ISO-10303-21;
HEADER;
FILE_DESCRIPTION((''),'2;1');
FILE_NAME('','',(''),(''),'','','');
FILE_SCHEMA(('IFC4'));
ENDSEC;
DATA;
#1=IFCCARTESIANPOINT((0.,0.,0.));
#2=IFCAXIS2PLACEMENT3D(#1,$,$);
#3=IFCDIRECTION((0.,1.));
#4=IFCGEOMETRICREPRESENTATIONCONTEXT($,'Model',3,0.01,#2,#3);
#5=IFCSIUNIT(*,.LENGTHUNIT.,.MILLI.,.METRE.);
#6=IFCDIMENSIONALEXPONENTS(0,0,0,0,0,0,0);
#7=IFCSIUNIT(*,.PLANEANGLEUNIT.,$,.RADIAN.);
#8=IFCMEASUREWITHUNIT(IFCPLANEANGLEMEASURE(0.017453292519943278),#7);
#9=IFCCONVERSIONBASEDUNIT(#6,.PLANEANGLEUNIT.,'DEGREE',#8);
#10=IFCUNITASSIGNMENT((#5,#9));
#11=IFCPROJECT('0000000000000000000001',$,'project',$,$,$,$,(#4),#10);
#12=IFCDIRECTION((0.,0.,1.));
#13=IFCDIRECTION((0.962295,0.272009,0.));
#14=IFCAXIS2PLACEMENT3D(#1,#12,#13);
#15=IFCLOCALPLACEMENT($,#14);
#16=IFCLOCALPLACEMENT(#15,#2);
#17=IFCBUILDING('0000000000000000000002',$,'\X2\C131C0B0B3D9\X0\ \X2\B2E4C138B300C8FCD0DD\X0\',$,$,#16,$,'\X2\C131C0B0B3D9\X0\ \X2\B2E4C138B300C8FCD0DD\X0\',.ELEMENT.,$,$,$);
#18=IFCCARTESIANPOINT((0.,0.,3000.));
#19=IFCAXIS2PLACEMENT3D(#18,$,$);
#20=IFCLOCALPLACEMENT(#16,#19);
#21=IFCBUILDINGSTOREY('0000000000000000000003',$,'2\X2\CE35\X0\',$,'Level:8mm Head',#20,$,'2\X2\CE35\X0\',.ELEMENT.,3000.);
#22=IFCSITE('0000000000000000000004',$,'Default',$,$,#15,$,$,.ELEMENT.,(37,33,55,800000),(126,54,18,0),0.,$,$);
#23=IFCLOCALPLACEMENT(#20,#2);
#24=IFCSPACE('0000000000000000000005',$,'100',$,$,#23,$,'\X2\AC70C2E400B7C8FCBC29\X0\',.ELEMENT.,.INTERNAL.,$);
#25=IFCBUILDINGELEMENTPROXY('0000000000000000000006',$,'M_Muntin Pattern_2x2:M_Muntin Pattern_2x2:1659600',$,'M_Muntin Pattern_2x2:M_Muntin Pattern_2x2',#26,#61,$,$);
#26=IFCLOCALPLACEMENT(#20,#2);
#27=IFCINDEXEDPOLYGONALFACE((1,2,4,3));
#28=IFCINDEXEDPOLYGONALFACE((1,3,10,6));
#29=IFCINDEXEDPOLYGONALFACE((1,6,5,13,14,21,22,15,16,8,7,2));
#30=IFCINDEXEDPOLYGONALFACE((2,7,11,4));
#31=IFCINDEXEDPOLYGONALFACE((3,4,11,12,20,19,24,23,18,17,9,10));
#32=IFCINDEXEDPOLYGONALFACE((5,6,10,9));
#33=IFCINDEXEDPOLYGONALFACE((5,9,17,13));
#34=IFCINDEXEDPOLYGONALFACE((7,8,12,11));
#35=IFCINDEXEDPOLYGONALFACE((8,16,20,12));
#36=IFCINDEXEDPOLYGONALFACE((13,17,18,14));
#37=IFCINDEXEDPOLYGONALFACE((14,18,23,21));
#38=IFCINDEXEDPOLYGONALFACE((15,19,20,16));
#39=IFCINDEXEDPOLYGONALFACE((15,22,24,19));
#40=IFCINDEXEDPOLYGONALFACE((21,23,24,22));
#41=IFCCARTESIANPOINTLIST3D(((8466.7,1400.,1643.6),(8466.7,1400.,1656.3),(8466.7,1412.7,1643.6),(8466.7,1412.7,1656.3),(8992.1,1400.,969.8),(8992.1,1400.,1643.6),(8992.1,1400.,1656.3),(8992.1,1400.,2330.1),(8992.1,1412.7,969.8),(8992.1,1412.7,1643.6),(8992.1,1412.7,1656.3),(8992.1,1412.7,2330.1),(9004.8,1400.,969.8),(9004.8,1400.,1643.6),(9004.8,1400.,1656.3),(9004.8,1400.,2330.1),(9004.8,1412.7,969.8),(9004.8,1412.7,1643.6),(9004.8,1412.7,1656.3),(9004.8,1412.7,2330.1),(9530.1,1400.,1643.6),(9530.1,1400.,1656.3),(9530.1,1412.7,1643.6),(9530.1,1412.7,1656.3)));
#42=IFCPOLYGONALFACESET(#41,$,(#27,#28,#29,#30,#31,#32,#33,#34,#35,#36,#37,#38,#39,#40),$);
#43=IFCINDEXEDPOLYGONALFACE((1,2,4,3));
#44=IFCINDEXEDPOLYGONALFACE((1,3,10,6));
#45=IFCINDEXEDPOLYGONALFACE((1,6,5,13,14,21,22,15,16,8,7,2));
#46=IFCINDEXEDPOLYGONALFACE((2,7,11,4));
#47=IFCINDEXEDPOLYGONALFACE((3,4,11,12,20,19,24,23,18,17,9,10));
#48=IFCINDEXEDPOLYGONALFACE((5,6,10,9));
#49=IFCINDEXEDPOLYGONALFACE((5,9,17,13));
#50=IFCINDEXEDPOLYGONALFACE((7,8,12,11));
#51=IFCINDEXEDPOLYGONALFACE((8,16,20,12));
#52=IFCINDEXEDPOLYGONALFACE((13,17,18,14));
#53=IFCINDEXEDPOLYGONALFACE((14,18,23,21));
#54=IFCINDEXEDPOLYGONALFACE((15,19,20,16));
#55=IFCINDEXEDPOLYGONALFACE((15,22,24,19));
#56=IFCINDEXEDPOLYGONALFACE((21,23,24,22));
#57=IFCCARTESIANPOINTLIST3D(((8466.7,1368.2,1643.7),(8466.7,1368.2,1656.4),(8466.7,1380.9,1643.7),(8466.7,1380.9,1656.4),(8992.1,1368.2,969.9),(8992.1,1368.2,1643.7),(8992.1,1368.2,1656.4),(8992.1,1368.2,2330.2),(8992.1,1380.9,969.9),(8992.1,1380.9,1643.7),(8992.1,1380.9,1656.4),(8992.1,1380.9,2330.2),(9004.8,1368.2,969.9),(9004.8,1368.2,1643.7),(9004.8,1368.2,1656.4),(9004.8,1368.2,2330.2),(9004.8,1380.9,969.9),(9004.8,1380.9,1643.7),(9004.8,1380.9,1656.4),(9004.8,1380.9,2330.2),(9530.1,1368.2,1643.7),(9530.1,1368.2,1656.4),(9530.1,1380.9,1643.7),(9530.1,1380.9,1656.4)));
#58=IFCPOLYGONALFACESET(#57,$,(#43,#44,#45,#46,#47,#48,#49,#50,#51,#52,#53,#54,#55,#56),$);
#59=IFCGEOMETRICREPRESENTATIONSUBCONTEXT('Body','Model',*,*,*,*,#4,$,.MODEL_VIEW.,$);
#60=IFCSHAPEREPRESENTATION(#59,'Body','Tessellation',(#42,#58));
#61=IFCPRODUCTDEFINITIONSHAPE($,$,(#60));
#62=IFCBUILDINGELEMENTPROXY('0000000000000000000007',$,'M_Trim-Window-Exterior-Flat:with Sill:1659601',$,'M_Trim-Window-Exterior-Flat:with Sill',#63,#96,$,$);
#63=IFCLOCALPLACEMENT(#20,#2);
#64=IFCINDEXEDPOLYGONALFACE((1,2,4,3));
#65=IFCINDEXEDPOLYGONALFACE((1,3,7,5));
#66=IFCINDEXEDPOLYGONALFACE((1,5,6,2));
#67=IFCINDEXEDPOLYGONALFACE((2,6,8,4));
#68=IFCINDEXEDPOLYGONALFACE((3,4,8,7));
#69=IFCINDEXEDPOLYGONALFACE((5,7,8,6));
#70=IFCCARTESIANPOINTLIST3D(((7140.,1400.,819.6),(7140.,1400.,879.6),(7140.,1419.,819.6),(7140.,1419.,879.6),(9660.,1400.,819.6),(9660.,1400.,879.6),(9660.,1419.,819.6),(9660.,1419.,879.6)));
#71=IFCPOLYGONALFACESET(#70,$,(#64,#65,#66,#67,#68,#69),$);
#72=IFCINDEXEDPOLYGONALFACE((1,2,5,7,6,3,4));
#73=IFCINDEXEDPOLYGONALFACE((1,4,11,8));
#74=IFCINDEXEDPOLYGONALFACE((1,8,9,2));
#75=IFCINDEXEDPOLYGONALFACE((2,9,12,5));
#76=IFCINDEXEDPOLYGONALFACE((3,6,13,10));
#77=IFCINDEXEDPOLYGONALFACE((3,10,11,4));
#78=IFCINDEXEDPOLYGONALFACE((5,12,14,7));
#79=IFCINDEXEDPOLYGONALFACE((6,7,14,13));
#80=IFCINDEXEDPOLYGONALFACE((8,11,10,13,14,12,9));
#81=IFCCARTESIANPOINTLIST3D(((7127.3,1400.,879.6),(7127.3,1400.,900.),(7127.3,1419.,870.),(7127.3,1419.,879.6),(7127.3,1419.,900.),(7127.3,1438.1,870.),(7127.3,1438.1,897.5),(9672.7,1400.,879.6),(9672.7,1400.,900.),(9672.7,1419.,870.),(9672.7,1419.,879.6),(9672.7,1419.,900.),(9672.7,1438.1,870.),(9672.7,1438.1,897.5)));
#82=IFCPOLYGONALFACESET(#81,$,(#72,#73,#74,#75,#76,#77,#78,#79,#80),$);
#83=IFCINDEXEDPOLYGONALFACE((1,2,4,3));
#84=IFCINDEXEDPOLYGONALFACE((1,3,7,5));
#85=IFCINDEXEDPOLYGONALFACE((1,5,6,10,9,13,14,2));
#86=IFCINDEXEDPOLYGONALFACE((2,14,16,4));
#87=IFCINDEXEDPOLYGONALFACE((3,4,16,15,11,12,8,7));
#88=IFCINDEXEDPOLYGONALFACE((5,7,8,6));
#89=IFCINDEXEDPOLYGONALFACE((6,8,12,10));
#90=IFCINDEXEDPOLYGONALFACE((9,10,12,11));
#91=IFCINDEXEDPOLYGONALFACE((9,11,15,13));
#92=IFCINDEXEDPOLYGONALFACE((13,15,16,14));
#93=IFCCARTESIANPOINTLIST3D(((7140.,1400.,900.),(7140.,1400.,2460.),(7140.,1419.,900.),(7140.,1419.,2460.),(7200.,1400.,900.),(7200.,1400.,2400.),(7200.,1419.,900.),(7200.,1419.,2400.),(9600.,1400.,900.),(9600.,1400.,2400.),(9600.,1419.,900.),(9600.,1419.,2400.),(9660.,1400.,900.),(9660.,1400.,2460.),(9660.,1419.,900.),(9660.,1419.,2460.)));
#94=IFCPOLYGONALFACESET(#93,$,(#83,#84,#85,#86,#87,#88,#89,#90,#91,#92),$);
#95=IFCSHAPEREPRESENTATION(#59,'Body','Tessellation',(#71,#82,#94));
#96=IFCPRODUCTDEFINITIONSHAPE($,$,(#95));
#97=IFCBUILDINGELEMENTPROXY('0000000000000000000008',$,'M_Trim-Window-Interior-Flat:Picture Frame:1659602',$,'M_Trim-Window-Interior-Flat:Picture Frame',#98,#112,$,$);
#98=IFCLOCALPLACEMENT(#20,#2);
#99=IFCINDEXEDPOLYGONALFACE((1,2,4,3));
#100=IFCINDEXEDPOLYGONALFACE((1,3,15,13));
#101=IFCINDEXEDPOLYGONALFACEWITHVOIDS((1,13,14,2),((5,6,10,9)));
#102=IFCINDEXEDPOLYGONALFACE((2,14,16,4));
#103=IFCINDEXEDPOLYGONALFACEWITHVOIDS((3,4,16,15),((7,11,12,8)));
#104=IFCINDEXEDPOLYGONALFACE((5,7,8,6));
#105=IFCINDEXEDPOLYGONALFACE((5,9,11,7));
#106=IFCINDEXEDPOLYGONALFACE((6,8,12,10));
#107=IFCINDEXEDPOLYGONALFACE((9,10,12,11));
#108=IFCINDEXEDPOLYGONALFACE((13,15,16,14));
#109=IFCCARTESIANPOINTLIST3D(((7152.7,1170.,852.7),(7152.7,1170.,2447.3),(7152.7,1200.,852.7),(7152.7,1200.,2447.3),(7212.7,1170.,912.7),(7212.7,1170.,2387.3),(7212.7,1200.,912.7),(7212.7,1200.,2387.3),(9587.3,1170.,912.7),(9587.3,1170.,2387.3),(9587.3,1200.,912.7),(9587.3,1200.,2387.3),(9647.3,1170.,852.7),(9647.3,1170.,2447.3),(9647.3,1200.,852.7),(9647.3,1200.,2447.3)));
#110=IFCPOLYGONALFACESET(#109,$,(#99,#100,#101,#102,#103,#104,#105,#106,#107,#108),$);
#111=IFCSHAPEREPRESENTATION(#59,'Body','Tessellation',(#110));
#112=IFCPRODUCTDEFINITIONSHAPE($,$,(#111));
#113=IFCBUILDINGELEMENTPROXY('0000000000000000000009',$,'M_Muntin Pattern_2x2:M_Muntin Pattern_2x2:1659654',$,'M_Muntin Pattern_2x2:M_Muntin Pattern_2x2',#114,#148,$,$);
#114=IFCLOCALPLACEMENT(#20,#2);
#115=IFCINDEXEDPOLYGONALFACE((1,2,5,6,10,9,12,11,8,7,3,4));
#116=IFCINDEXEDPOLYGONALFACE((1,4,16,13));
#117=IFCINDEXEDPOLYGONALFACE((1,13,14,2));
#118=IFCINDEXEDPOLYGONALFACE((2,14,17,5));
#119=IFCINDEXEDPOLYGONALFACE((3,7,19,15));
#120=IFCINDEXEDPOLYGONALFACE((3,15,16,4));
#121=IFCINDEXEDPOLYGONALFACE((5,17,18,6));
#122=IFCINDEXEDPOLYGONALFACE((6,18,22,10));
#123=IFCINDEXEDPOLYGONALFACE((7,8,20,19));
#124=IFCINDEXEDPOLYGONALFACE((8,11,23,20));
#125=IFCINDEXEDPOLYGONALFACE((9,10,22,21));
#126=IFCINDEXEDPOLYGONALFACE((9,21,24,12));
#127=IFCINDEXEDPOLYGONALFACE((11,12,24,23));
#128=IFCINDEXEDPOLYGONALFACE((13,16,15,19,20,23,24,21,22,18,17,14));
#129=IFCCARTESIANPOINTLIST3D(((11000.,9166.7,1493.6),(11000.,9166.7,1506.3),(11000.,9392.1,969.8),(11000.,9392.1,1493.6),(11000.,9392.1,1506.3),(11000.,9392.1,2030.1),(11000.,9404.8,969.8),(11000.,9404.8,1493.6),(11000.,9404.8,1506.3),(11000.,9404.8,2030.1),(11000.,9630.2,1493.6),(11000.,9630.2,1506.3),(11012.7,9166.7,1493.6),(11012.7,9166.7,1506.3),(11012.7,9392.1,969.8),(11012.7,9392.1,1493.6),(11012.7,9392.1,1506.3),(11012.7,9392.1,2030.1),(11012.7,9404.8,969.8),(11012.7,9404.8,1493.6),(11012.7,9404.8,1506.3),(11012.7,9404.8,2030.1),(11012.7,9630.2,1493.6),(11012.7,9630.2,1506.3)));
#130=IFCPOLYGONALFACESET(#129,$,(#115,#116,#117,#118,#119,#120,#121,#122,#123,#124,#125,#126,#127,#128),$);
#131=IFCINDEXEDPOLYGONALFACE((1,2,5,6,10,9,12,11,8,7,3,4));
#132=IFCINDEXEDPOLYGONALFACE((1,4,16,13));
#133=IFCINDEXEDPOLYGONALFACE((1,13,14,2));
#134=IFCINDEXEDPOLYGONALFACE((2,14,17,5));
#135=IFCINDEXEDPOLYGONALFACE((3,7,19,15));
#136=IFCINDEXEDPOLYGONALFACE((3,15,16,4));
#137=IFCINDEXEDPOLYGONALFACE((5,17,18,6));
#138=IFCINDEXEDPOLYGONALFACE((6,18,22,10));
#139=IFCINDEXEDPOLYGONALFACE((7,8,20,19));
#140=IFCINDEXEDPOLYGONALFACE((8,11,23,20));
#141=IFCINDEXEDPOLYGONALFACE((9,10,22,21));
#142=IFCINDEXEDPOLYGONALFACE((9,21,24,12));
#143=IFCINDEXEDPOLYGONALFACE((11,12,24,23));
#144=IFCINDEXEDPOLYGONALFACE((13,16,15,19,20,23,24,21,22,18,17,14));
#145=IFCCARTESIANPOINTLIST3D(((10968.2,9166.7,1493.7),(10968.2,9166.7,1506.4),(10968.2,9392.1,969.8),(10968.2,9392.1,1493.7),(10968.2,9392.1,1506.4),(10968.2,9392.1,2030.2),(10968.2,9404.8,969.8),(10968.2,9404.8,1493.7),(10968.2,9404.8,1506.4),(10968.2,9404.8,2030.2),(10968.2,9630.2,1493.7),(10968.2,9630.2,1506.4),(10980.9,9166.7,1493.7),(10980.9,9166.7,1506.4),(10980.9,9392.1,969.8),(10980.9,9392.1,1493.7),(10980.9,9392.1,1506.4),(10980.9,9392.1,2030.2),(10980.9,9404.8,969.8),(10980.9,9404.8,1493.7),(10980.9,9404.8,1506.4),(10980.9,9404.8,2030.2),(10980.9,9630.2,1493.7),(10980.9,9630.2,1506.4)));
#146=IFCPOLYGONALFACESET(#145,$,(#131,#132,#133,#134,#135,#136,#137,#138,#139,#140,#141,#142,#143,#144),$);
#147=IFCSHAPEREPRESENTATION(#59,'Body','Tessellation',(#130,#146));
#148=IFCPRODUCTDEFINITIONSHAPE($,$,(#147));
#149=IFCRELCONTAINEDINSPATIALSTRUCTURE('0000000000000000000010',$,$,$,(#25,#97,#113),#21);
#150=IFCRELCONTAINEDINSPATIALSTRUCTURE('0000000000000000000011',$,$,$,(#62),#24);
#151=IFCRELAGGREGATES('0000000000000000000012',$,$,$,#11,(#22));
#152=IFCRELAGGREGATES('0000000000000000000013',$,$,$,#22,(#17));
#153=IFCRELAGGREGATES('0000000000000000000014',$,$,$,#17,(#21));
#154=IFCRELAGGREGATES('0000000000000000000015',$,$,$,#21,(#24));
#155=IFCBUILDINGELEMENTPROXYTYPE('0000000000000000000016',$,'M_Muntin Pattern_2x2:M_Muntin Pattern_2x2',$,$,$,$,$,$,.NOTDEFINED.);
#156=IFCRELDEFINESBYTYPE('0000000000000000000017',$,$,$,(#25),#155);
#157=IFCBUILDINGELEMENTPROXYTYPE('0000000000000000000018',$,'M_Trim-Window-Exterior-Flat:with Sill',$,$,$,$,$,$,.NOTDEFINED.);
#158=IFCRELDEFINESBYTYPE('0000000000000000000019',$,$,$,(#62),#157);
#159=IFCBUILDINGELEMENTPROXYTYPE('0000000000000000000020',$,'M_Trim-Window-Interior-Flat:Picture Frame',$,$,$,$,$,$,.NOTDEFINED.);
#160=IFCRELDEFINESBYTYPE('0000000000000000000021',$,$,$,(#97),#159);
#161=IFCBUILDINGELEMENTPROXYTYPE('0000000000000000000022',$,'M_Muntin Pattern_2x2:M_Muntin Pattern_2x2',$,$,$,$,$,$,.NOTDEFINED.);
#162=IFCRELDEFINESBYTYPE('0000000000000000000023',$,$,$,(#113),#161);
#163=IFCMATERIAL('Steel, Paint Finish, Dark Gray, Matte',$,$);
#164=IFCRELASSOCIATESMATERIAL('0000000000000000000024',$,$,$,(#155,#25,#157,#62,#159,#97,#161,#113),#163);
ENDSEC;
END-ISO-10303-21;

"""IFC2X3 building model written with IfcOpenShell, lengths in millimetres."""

from ifc_helpers import new_model, entity, si_unit, converted_unit, direction, frame, frame_2d, origin, place, context, subcontext, project, spatial, polyline, rectangle, outline, extrude, source, transform, mapped, material, type_object, type_shapes, element, save


model = new_model("IFC2X3")

# Units and contexts
model_context = context("Model", 3, precision=0.01, world=origin(), true_north=direction((0.0, 1.0)))
body_context = subcontext(model_context, "Body", "Model", "MODEL_VIEW")
ifc_project = project(units=[si_unit("LENGTHUNIT", "METRE", prefix="MILLI"), converted_unit("PLANEANGLEUNIT", "DEGREE", entity("IfcPlaneAngleMeasure", 0.017453292519943278), si_unit("PLANEANGLEUNIT", "RADIAN"), dimensions=[0, 0, 0, 0, 0, 0, 0])], contexts=[model_context])

# Site, building, storey
site_placement = place(None, frame((0.0, 0.0, 0.0), z_axis=(0.0, 0.0, 1.0), x_axis=(0.962295, 0.272009, 0.0)))
site = spatial("IfcSite", under=ifc_project, at=site_placement, Name="Default", CompositionType="ELEMENT", RefLatitude=(37, 33, 55, 800000), RefLongitude=(126, 54, 18, 0), RefElevation=0.0)
building_placement = place(site_placement, origin())
building = spatial("IfcBuilding", under=site, at=building_placement, Name="성산동 다세대주택", LongName="성산동 다세대주택", CompositionType="ELEMENT")
storey_placement = place(building_placement, frame((0.0, 0.0, 3000.0)))
storey = spatial("IfcBuildingStorey", under=building, at=storey_placement, Name="2층", ObjectType="Level:8mm Head", LongName="2층", CompositionType="ELEMENT", Elevation=3000.0)

# Shared definitions
ifc_material_1 = material(Name="Steel, Paint Finish, Dark Gray, Matte")

# Shared definitions
space_1_placement = place(storey_placement, origin())
space_1 = spatial("IfcSpace", under=storey, at=space_1_placement, Name="100", LongName="거실·주방", CompositionType="ELEMENT", InteriorOrExteriorSpace="INTERNAL")

# Building element proxies
building_element_proxy_type_1 = type_object("IfcBuildingElementProxyType", Name="M_Muntin Pattern_2x2:M_Muntin Pattern_2x2", PredefinedType="NOTDEFINED", material=ifc_material_1)
shared_shape_1 = source(origin(), body_context, "Body", "SweptSolid", [
    extrude(outline(polyline([(6.4, -6.4), (680.1, -6.4), (680.1, 6.3), (6.4, 6.3), (6.4, 531.7), (-6.3, 531.7), (-6.3, 6.3), (-680.2, 6.3), (-680.2, -6.4), (-6.3, -6.4), (-6.3, -531.7), (6.4, -531.7), (6.4, -6.4)])), frame((0.0, -22.2, 680.1), z_axis=(0.0, 1.0, 0.0), x_axis=(0.0, 0.0, 1.0)), (0.0, 0.0, 1.0), 12.7),
    extrude(outline(polyline([(6.4, -6.4), (680.2, -6.4), (680.2, 6.3), (6.4, 6.3), (6.4, 531.7), (-6.3, 531.7), (-6.3, 6.3), (-680.2, 6.3), (-680.2, -6.4), (-6.3, -6.4), (-6.3, -531.7), (6.4, -531.7), (6.4, -6.4)])), frame((0.0, 9.5, 680.2), z_axis=(0.0, 1.0, 0.0), x_axis=(0.0, 0.0, 1.0)), (0.0, 0.0, 1.0), 12.7),
])
type_shapes(building_element_proxy_type_1, [shared_shape_1])
proxy_1_placement = place(storey_placement, frame((8998.4, 1390.5, 969.9), z_axis=(0.0, 0.0, 1.0), x_axis=(-1.0, 0.0, 0.0)))
element("IfcBuildingElementProxy", 1, at=proxy_1_placement, inside=storey, type_object=building_element_proxy_type_1, material=ifc_material_1, Name="M_Muntin Pattern_2x2:M_Muntin Pattern_2x2:1659600", ObjectType="M_Muntin Pattern_2x2:M_Muntin Pattern_2x2", context=body_context, shape_type="MappedRepresentation", body=[
    mapped(shared_shape_1, transform((0.0, 0.0, 0.0), scale=1.0)),
])
building_element_proxy_type_2 = type_object("IfcBuildingElementProxyType", Name="M_Trim-Window-Exterior-Flat:with Sill", PredefinedType="NOTDEFINED", material=ifc_material_1)
shared_shape_2 = source(origin(), body_context, "Body", "SweptSolid", [
    extrude(rectangle(XDim=2520.0, YDim=60.0, at=frame_2d((0.0, 0.0), x_axis=(1.0, 0.0))), frame((0.0, -1550.4, 0.0), z_axis=(0.0, 0.0, 1.0), x_axis=(-1.0, 0.0, 0.0)), (0.0, 0.0, 1.0), 19.0),
    extrude(outline(polyline([(-19.0, -15.2), (0.0, -15.2), (0.0, -5.7), (19.0, -5.7), (19.0, 14.8), (0.0, 14.8), (-19.0, 12.3), (-19.0, -15.2)])), frame((-1272.7, -1514.8, 19.0), z_axis=(1.0, 0.0, 0.0), x_axis=(0.0, 0.0, -1.0)), (0.0, 0.0, 1.0), 2545.4),
    extrude(outline(polyline([(-795.0, -1260.0), (765.0, -1260.0), (765.0, -1200.0), (-735.0, -1200.0), (-735.0, 1200.0), (765.0, 1200.0), (765.0, 1260.0), (-795.0, 1260.0), (-795.0, -1260.0)])), frame((0.0, -735.0, 0.0), z_axis=(0.0, 0.0, 1.0), x_axis=(0.0, -1.0, 0.0)), (0.0, 0.0, 1.0), 19.0),
])
type_shapes(building_element_proxy_type_2, [shared_shape_2])
proxy_2_placement = place(space_1_placement, frame((8400.0, 1400.0, 2400.0), z_axis=(0.0, 1.0, 0.0), x_axis=(-1.0, 0.0, 0.0)))
element("IfcBuildingElementProxy", 2, at=proxy_2_placement, inside=space_1, type_object=building_element_proxy_type_2, material=ifc_material_1, Name="M_Trim-Window-Exterior-Flat:with Sill:1659601", ObjectType="M_Trim-Window-Exterior-Flat:with Sill", context=body_context, shape_type="MappedRepresentation", body=[
    mapped(shared_shape_2, transform((0.0, 0.0, 0.0), scale=1.0)),
])
building_element_proxy_type_3 = type_object("IfcBuildingElementProxyType", Name="M_Trim-Window-Interior-Flat:Picture Frame", PredefinedType="NOTDEFINED", material=ifc_material_1)
shared_shape_3 = source(origin(), body_context, "Body", "SweptSolid", [
    extrude(outline(polyline([(-1247.3, -797.3), (1247.3, -797.3), (1247.3, 797.3), (-1247.3, 797.3), (-1247.3, -797.3)]), holes=[polyline([(-1187.3, -737.3), (-1187.3, 737.3), (1187.3, 737.3), (1187.3, -737.3), (-1187.3, -737.3)])]), frame((0.0, -750.0, 0.0), z_axis=(0.0, 0.0, 1.0), x_axis=(-1.0, 0.0, 0.0)), (0.0, 0.0, 1.0), 30.0),
])
type_shapes(building_element_proxy_type_3, [shared_shape_3])
proxy_3_placement = place(storey_placement, frame((8400.0, 1200.0, 2400.0), z_axis=(0.0, -1.0, 0.0), x_axis=(1.0, 0.0, 0.0)))
element("IfcBuildingElementProxy", 3, at=proxy_3_placement, inside=storey, type_object=building_element_proxy_type_3, material=ifc_material_1, Name="M_Trim-Window-Interior-Flat:Picture Frame:1659602", ObjectType="M_Trim-Window-Interior-Flat:Picture Frame", context=body_context, shape_type="MappedRepresentation", body=[
    mapped(shared_shape_3, transform((0.0, 0.0, 0.0), scale=1.0)),
])
building_element_proxy_type_4 = type_object("IfcBuildingElementProxyType", Name="M_Muntin Pattern_2x2:M_Muntin Pattern_2x2", PredefinedType="NOTDEFINED", material=ifc_material_1)
shared_shape_4 = source(origin(), body_context, "Body", "SweptSolid", [
    extrude(outline(polyline([(6.4, -6.4), (530.1, -6.4), (530.1, 6.3), (6.4, 6.3), (6.4, 231.7), (-6.3, 231.7), (-6.3, 6.3), (-530.2, 6.3), (-530.2, -6.4), (-6.3, -6.4), (-6.3, -231.7), (6.4, -231.7), (6.4, -6.4)])), frame((0.0, 9.5, 530.1), z_axis=(0.0, 1.0, 0.0), x_axis=(0.0, 0.0, 1.0)), (0.0, 0.0, 1.0), 12.7),
    extrude(outline(polyline([(6.4, -6.4), (530.2, -6.4), (530.2, 6.3), (6.4, 6.3), (6.4, 231.7), (-6.3, 231.7), (-6.3, 6.3), (-530.2, 6.3), (-530.2, -6.4), (-6.3, -6.4), (-6.3, -231.7), (6.4, -231.7), (6.4, -6.4)])), frame((0.0, -22.2, 530.2), z_axis=(0.0, 1.0, 0.0), x_axis=(0.0, 0.0, 1.0)), (0.0, 0.0, 1.0), 12.7),
])
type_shapes(building_element_proxy_type_4, [shared_shape_4])
proxy_4_placement = place(storey_placement, frame((10990.5, 9398.4, 969.8), z_axis=(0.0, 0.0, 1.0), x_axis=(0.0, -1.0, 0.0)))
element("IfcBuildingElementProxy", 4, at=proxy_4_placement, inside=storey, type_object=building_element_proxy_type_4, material=ifc_material_1, Name="M_Muntin Pattern_2x2:M_Muntin Pattern_2x2:1659654", ObjectType="M_Muntin Pattern_2x2:M_Muntin Pattern_2x2", context=body_context, shape_type="MappedRepresentation", body=[
    mapped(shared_shape_4, transform((0.0, 0.0, 0.0), scale=1.0)),
])

save(model, "model.ifc")
